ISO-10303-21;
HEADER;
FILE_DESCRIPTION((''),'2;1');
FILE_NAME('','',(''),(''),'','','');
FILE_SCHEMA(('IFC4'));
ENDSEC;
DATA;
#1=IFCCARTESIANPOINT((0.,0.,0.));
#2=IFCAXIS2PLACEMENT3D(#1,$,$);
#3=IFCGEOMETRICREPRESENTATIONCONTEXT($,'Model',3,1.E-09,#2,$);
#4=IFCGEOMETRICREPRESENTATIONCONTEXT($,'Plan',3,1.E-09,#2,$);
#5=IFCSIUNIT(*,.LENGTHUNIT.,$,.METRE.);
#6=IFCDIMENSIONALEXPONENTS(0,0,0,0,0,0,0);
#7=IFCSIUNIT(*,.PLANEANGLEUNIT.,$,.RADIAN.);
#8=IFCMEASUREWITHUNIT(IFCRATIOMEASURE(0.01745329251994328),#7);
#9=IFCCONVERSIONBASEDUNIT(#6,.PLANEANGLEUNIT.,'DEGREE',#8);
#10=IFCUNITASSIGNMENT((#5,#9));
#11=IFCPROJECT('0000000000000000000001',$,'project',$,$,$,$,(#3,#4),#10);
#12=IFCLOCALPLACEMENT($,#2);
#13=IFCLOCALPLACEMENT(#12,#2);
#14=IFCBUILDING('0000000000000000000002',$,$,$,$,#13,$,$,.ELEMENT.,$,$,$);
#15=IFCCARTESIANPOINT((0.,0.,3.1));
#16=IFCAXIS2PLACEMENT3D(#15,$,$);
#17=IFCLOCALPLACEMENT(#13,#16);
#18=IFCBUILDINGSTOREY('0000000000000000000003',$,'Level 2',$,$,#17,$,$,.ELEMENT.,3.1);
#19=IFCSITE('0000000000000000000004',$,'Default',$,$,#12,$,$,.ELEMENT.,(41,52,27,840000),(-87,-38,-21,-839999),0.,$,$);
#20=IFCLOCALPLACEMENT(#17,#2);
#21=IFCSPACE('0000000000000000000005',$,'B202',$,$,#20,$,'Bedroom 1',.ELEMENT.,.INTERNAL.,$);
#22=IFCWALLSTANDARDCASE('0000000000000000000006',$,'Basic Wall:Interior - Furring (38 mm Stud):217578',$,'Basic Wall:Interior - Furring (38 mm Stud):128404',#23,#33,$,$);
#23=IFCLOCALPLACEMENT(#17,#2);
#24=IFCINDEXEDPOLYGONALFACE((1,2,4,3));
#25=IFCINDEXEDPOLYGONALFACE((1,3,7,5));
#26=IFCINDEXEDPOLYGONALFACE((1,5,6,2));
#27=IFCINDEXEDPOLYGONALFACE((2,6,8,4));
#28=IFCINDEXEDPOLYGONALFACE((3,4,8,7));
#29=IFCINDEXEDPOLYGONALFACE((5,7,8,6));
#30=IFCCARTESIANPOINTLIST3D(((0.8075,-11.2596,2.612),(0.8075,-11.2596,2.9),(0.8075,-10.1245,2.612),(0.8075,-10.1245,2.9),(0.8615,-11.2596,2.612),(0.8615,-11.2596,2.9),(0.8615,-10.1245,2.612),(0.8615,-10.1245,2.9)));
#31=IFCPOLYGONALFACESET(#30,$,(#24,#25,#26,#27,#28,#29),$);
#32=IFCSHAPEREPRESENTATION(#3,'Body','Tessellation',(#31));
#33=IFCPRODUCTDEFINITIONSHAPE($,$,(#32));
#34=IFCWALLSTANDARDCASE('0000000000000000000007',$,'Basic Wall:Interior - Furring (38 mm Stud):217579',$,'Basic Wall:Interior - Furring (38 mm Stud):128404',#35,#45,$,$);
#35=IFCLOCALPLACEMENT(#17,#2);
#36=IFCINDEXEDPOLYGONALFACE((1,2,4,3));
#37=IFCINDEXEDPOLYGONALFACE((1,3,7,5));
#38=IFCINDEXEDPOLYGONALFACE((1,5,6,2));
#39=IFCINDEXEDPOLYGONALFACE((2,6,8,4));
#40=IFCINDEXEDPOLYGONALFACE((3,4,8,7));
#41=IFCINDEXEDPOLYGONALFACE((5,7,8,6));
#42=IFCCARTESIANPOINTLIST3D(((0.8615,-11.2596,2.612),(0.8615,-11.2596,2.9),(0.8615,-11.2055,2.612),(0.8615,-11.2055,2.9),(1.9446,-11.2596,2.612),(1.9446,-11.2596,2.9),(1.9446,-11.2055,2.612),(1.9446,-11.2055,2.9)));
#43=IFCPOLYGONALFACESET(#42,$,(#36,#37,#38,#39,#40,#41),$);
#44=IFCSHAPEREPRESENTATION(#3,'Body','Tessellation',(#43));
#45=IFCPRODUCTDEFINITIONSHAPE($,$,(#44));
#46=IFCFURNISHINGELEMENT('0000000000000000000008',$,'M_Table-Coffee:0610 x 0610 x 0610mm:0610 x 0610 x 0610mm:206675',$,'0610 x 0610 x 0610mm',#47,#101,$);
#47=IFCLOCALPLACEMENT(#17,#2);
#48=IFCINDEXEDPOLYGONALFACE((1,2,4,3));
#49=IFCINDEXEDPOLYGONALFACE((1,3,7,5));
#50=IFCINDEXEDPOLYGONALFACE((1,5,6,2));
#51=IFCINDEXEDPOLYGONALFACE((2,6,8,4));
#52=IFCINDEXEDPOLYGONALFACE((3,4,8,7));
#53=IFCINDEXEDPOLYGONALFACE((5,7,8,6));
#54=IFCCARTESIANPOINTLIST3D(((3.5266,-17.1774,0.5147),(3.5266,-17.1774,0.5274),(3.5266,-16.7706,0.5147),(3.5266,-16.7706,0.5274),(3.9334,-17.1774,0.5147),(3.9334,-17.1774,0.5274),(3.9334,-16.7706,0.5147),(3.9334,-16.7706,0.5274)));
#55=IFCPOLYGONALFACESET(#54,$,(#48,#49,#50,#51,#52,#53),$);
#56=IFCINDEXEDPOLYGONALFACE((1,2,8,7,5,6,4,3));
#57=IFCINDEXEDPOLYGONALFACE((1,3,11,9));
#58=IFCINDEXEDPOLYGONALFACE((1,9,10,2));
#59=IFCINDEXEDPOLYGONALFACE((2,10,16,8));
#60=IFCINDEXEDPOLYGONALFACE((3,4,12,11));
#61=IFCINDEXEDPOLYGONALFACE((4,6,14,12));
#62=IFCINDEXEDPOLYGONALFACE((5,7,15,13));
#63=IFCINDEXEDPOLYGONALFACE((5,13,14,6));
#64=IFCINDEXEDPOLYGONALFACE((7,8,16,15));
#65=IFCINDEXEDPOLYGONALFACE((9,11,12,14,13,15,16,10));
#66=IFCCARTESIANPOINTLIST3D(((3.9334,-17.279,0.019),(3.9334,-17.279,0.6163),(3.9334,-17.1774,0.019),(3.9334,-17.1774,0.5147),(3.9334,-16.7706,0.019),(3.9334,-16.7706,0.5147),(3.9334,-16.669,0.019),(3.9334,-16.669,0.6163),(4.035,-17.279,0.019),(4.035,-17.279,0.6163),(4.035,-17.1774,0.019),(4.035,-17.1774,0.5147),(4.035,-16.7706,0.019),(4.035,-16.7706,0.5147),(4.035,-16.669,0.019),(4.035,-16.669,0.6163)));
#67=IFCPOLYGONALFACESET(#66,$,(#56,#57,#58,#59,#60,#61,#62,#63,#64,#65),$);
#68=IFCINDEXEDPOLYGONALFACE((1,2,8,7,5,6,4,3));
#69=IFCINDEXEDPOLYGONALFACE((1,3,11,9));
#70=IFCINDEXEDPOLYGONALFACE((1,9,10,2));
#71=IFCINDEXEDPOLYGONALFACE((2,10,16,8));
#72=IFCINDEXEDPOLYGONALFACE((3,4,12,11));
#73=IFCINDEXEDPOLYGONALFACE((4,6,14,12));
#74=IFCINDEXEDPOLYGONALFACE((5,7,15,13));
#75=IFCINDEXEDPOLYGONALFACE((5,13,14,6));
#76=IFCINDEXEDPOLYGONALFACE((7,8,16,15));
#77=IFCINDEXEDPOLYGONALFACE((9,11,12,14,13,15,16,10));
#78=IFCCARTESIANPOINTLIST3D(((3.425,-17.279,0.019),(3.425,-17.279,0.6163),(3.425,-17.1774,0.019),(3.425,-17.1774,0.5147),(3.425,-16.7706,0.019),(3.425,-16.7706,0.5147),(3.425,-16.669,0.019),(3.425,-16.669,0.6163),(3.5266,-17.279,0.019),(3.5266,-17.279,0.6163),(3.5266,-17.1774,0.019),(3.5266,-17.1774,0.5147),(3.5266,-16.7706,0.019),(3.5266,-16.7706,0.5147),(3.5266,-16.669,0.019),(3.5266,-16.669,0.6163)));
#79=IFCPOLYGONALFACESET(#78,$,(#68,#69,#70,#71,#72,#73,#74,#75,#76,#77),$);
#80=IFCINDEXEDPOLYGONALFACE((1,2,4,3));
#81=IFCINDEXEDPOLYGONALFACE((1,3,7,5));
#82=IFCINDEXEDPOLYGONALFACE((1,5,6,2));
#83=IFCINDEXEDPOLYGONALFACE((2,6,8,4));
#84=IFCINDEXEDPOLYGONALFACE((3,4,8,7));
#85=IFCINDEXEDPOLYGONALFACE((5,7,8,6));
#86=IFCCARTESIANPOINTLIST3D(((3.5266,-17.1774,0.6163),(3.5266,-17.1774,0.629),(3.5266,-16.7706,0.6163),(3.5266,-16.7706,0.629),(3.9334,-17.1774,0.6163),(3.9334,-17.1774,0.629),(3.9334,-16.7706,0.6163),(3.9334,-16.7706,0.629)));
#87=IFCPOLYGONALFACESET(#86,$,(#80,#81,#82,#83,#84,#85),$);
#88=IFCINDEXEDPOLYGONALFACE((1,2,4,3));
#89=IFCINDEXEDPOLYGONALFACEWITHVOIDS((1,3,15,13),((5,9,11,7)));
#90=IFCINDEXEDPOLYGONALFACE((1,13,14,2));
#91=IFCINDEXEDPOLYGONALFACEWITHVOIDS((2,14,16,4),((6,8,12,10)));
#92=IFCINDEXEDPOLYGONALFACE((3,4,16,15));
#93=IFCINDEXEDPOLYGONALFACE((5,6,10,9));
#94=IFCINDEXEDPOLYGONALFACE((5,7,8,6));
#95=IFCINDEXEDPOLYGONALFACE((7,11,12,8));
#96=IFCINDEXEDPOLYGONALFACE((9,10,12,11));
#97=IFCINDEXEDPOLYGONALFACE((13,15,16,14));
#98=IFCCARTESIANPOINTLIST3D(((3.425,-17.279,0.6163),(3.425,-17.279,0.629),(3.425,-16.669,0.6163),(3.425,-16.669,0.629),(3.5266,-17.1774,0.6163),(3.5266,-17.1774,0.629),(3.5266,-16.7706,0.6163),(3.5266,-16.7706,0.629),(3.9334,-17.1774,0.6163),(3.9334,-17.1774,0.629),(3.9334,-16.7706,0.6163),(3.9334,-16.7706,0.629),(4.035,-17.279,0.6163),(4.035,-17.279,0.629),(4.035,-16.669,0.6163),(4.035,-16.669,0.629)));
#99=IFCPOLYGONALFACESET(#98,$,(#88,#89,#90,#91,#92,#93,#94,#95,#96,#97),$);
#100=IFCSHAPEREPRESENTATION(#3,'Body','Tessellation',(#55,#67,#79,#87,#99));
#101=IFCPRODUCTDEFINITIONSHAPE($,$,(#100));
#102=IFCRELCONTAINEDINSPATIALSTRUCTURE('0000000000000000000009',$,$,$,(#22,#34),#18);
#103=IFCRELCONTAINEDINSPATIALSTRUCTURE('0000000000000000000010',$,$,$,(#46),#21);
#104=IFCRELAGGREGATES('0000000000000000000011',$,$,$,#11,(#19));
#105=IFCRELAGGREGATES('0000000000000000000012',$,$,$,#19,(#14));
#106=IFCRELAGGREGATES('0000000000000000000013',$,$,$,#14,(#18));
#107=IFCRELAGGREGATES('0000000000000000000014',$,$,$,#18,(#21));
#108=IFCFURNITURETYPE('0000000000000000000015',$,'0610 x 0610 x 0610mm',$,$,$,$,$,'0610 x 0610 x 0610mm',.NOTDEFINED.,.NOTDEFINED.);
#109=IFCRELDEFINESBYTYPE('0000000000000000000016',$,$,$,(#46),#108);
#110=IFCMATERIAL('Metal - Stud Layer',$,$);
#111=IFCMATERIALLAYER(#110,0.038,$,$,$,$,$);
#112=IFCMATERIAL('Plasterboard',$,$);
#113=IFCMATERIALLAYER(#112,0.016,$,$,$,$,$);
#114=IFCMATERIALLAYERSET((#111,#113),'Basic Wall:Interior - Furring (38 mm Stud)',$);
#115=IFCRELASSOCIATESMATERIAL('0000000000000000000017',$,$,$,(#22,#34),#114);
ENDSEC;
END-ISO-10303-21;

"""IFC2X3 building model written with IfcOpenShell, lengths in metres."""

from ifc_helpers import new_model, entity, si_unit, converted_unit, frame, frame_2d, origin, origin_2d_with_axis, place, context, project, spatial, polyline, rectangle, outline, extrude, source, transform, mapped, material, layer, layer_set, layer_usage, type_object, type_shapes, element, save


model = new_model("IFC2X3")

# Units and contexts
model_context = context("Model", 3, precision=1e-09, world=origin())
plan_context = context("Plan", 3, precision=1e-09, world=origin())
ifc_project = project(units=[si_unit("LENGTHUNIT", "METRE"), converted_unit("PLANEANGLEUNIT", "DEGREE", entity("IfcRatioMeasure", 0.01745329251994328), si_unit("PLANEANGLEUNIT", "RADIAN"), dimensions=[0, 0, 0, 0, 0, 0, 0])], contexts=[model_context, plan_context])

# Site, building, storey
site_placement = place(None, origin())
site = spatial("IfcSite", under=ifc_project, at=site_placement, Name="Default", CompositionType="ELEMENT", RefLatitude=(41, 52, 27, 840000), RefLongitude=(-87, -38, -21, -839999), RefElevation=0.0)
building_placement = place(site_placement, origin())
building = spatial("IfcBuilding", under=site, at=building_placement, CompositionType="ELEMENT")
storey_placement = place(building_placement, frame((0.0, 0.0, 3.1)))
storey = spatial("IfcBuildingStorey", under=building, at=storey_placement, Name="Level 2", CompositionType="ELEMENT", Elevation=3.1)

# Shared definitions
ifc_material_1 = material(Name="Metal - Stud Layer")
ifc_material_2 = material(Name="Plasterboard")

# Walls
ifc_layer_1 = layer(ifc_material_1, 0.038)
ifc_layer_2 = layer(ifc_material_2, 0.016)
ifc_layer_set_1 = layer_set([ifc_layer_1, ifc_layer_2], Name="Basic Wall:Interior - Furring (38 mm Stud)")
ifc_layer_usage_1 = layer_usage(ifc_layer_set_1, "AXIS2", "NEGATIVE", 0.027)
wall_1_placement = place(storey_placement, frame((0.8345, -11.2596, 2.612), z_axis=(0.0, 0.0, 1.0), x_axis=(0.0, 1.0, 0.0)))
element("IfcWallStandardCase", 1, at=wall_1_placement, inside=storey, material=ifc_layer_usage_1, Name="Basic Wall:Interior - Furring (38 mm Stud):217578", ObjectType="Basic Wall:Interior - Furring (38 mm Stud):128404", context=model_context, shape_type="SweptSolid", body=[
    extrude(rectangle(XDim=1.1351, YDim=0.054, at=frame_2d((0.5675, 0.0), x_axis=(-1.0, 0.0))), origin(), (0.0, 0.0, 1.0), 0.288),
])
wall_2_placement = place(storey_placement, frame((1.9446, -11.2325, 2.612), z_axis=(0.0, 0.0, 1.0), x_axis=(-1.0, 0.0, 0.0)))
element("IfcWallStandardCase", 2, at=wall_2_placement, inside=storey, material=ifc_layer_usage_1, Name="Basic Wall:Interior - Furring (38 mm Stud):217579", ObjectType="Basic Wall:Interior - Furring (38 mm Stud):128404", context=model_context, shape_type="SweptSolid", body=[
    extrude(rectangle(XDim=1.0831, YDim=0.054, at=frame_2d((0.5415, 0.0), x_axis=(-1.0, 0.0))), origin(), (0.0, 0.0, 1.0), 0.288),
])

# Shared definitions
space_placement = place(storey_placement, origin())
space = spatial("IfcSpace", under=storey, at=space_placement, Name="B202", LongName="Bedroom 1", CompositionType="ELEMENT", InteriorOrExteriorSpace="INTERNAL")

# Furnishing element
furniture_type = type_object("IfcFurnitureType", Name="0610 x 0610 x 0610mm", ElementType="0610 x 0610 x 0610mm", AssemblyPlace="NOTDEFINED")
shared_shape_1 = source(origin(), model_context, "Body", "SweptSolid", [
    extrude(rectangle(XDim=0.4068, YDim=0.4068, at=origin_2d_with_axis()), frame((0.0183, 0.0952, 0.4957), z_axis=(0.0, 0.0, 1.0), x_axis=(-1.0, 0.0, 0.0)), (0.0, 0.0, 1.0), 0.0127),
    extrude(outline(polyline([(-0.2732, -0.305), (0.324, -0.305), (0.324, 0.305), (-0.2732, 0.305), (-0.2732, 0.2034), (0.2225, 0.2034), (0.2225, -0.2034), (-0.2732, -0.2034), (-0.2732, -0.305)])), frame((0.2217, 0.0952, 0.2732), z_axis=(1.0, 0.0, 0.0), x_axis=(0.0, 0.0, 1.0)), (0.0, 0.0, 1.0), 0.1016),
    extrude(outline(polyline([(-0.305, -0.3241), (0.305, -0.3241), (0.305, 0.2733), (0.2034, 0.2733), (0.2034, -0.2224), (-0.2034, -0.2224), (-0.2034, 0.2733), (-0.305, 0.2733), (-0.305, -0.3241)])), frame((-0.2867, 0.0952, 0.2733), z_axis=(1.0, 0.0, 0.0), x_axis=(0.0, -1.0, 0.0)), (0.0, 0.0, 1.0), 0.1016),
    extrude(rectangle(XDim=0.4068, YDim=0.4068, at=origin_2d_with_axis()), frame((0.0183, 0.0952, 0.5973), z_axis=(0.0, 0.0, 1.0), x_axis=(-1.0, 0.0, 0.0)), (0.0, 0.0, 1.0), 0.0127),
    extrude(outline(polyline([(-0.305, -0.305), (0.305, -0.305), (0.305, 0.305), (-0.305, 0.305), (-0.305, -0.305)]), holes=[polyline([(-0.2034, -0.2034), (-0.2034, 0.2034), (0.2034, 0.2034), (0.2034, -0.2034), (-0.2034, -0.2034)])]), frame((0.0183, 0.0952, 0.5973), z_axis=(0.0, 0.0, 1.0), x_axis=(-1.0, 0.0, 0.0)), (0.0, 0.0, 1.0), 0.0127),
])
type_shapes(furniture_type, [shared_shape_1])
furnishing_placement = place(space_placement, frame((3.7117, -17.0692, 0.019)))
element("IfcFurnishingElement", 3, at=furnishing_placement, inside=space, type_object=furniture_type, Name="M_Table-Coffee:0610 x 0610 x 0610mm:0610 x 0610 x 0610mm:206675", ObjectType="0610 x 0610 x 0610mm", context=model_context, shape_type="MappedRepresentation", body=[
    mapped(shared_shape_1, transform((0.0, 0.0, 0.0), scale=1.0)),
])

save(model, "model.ifc")
